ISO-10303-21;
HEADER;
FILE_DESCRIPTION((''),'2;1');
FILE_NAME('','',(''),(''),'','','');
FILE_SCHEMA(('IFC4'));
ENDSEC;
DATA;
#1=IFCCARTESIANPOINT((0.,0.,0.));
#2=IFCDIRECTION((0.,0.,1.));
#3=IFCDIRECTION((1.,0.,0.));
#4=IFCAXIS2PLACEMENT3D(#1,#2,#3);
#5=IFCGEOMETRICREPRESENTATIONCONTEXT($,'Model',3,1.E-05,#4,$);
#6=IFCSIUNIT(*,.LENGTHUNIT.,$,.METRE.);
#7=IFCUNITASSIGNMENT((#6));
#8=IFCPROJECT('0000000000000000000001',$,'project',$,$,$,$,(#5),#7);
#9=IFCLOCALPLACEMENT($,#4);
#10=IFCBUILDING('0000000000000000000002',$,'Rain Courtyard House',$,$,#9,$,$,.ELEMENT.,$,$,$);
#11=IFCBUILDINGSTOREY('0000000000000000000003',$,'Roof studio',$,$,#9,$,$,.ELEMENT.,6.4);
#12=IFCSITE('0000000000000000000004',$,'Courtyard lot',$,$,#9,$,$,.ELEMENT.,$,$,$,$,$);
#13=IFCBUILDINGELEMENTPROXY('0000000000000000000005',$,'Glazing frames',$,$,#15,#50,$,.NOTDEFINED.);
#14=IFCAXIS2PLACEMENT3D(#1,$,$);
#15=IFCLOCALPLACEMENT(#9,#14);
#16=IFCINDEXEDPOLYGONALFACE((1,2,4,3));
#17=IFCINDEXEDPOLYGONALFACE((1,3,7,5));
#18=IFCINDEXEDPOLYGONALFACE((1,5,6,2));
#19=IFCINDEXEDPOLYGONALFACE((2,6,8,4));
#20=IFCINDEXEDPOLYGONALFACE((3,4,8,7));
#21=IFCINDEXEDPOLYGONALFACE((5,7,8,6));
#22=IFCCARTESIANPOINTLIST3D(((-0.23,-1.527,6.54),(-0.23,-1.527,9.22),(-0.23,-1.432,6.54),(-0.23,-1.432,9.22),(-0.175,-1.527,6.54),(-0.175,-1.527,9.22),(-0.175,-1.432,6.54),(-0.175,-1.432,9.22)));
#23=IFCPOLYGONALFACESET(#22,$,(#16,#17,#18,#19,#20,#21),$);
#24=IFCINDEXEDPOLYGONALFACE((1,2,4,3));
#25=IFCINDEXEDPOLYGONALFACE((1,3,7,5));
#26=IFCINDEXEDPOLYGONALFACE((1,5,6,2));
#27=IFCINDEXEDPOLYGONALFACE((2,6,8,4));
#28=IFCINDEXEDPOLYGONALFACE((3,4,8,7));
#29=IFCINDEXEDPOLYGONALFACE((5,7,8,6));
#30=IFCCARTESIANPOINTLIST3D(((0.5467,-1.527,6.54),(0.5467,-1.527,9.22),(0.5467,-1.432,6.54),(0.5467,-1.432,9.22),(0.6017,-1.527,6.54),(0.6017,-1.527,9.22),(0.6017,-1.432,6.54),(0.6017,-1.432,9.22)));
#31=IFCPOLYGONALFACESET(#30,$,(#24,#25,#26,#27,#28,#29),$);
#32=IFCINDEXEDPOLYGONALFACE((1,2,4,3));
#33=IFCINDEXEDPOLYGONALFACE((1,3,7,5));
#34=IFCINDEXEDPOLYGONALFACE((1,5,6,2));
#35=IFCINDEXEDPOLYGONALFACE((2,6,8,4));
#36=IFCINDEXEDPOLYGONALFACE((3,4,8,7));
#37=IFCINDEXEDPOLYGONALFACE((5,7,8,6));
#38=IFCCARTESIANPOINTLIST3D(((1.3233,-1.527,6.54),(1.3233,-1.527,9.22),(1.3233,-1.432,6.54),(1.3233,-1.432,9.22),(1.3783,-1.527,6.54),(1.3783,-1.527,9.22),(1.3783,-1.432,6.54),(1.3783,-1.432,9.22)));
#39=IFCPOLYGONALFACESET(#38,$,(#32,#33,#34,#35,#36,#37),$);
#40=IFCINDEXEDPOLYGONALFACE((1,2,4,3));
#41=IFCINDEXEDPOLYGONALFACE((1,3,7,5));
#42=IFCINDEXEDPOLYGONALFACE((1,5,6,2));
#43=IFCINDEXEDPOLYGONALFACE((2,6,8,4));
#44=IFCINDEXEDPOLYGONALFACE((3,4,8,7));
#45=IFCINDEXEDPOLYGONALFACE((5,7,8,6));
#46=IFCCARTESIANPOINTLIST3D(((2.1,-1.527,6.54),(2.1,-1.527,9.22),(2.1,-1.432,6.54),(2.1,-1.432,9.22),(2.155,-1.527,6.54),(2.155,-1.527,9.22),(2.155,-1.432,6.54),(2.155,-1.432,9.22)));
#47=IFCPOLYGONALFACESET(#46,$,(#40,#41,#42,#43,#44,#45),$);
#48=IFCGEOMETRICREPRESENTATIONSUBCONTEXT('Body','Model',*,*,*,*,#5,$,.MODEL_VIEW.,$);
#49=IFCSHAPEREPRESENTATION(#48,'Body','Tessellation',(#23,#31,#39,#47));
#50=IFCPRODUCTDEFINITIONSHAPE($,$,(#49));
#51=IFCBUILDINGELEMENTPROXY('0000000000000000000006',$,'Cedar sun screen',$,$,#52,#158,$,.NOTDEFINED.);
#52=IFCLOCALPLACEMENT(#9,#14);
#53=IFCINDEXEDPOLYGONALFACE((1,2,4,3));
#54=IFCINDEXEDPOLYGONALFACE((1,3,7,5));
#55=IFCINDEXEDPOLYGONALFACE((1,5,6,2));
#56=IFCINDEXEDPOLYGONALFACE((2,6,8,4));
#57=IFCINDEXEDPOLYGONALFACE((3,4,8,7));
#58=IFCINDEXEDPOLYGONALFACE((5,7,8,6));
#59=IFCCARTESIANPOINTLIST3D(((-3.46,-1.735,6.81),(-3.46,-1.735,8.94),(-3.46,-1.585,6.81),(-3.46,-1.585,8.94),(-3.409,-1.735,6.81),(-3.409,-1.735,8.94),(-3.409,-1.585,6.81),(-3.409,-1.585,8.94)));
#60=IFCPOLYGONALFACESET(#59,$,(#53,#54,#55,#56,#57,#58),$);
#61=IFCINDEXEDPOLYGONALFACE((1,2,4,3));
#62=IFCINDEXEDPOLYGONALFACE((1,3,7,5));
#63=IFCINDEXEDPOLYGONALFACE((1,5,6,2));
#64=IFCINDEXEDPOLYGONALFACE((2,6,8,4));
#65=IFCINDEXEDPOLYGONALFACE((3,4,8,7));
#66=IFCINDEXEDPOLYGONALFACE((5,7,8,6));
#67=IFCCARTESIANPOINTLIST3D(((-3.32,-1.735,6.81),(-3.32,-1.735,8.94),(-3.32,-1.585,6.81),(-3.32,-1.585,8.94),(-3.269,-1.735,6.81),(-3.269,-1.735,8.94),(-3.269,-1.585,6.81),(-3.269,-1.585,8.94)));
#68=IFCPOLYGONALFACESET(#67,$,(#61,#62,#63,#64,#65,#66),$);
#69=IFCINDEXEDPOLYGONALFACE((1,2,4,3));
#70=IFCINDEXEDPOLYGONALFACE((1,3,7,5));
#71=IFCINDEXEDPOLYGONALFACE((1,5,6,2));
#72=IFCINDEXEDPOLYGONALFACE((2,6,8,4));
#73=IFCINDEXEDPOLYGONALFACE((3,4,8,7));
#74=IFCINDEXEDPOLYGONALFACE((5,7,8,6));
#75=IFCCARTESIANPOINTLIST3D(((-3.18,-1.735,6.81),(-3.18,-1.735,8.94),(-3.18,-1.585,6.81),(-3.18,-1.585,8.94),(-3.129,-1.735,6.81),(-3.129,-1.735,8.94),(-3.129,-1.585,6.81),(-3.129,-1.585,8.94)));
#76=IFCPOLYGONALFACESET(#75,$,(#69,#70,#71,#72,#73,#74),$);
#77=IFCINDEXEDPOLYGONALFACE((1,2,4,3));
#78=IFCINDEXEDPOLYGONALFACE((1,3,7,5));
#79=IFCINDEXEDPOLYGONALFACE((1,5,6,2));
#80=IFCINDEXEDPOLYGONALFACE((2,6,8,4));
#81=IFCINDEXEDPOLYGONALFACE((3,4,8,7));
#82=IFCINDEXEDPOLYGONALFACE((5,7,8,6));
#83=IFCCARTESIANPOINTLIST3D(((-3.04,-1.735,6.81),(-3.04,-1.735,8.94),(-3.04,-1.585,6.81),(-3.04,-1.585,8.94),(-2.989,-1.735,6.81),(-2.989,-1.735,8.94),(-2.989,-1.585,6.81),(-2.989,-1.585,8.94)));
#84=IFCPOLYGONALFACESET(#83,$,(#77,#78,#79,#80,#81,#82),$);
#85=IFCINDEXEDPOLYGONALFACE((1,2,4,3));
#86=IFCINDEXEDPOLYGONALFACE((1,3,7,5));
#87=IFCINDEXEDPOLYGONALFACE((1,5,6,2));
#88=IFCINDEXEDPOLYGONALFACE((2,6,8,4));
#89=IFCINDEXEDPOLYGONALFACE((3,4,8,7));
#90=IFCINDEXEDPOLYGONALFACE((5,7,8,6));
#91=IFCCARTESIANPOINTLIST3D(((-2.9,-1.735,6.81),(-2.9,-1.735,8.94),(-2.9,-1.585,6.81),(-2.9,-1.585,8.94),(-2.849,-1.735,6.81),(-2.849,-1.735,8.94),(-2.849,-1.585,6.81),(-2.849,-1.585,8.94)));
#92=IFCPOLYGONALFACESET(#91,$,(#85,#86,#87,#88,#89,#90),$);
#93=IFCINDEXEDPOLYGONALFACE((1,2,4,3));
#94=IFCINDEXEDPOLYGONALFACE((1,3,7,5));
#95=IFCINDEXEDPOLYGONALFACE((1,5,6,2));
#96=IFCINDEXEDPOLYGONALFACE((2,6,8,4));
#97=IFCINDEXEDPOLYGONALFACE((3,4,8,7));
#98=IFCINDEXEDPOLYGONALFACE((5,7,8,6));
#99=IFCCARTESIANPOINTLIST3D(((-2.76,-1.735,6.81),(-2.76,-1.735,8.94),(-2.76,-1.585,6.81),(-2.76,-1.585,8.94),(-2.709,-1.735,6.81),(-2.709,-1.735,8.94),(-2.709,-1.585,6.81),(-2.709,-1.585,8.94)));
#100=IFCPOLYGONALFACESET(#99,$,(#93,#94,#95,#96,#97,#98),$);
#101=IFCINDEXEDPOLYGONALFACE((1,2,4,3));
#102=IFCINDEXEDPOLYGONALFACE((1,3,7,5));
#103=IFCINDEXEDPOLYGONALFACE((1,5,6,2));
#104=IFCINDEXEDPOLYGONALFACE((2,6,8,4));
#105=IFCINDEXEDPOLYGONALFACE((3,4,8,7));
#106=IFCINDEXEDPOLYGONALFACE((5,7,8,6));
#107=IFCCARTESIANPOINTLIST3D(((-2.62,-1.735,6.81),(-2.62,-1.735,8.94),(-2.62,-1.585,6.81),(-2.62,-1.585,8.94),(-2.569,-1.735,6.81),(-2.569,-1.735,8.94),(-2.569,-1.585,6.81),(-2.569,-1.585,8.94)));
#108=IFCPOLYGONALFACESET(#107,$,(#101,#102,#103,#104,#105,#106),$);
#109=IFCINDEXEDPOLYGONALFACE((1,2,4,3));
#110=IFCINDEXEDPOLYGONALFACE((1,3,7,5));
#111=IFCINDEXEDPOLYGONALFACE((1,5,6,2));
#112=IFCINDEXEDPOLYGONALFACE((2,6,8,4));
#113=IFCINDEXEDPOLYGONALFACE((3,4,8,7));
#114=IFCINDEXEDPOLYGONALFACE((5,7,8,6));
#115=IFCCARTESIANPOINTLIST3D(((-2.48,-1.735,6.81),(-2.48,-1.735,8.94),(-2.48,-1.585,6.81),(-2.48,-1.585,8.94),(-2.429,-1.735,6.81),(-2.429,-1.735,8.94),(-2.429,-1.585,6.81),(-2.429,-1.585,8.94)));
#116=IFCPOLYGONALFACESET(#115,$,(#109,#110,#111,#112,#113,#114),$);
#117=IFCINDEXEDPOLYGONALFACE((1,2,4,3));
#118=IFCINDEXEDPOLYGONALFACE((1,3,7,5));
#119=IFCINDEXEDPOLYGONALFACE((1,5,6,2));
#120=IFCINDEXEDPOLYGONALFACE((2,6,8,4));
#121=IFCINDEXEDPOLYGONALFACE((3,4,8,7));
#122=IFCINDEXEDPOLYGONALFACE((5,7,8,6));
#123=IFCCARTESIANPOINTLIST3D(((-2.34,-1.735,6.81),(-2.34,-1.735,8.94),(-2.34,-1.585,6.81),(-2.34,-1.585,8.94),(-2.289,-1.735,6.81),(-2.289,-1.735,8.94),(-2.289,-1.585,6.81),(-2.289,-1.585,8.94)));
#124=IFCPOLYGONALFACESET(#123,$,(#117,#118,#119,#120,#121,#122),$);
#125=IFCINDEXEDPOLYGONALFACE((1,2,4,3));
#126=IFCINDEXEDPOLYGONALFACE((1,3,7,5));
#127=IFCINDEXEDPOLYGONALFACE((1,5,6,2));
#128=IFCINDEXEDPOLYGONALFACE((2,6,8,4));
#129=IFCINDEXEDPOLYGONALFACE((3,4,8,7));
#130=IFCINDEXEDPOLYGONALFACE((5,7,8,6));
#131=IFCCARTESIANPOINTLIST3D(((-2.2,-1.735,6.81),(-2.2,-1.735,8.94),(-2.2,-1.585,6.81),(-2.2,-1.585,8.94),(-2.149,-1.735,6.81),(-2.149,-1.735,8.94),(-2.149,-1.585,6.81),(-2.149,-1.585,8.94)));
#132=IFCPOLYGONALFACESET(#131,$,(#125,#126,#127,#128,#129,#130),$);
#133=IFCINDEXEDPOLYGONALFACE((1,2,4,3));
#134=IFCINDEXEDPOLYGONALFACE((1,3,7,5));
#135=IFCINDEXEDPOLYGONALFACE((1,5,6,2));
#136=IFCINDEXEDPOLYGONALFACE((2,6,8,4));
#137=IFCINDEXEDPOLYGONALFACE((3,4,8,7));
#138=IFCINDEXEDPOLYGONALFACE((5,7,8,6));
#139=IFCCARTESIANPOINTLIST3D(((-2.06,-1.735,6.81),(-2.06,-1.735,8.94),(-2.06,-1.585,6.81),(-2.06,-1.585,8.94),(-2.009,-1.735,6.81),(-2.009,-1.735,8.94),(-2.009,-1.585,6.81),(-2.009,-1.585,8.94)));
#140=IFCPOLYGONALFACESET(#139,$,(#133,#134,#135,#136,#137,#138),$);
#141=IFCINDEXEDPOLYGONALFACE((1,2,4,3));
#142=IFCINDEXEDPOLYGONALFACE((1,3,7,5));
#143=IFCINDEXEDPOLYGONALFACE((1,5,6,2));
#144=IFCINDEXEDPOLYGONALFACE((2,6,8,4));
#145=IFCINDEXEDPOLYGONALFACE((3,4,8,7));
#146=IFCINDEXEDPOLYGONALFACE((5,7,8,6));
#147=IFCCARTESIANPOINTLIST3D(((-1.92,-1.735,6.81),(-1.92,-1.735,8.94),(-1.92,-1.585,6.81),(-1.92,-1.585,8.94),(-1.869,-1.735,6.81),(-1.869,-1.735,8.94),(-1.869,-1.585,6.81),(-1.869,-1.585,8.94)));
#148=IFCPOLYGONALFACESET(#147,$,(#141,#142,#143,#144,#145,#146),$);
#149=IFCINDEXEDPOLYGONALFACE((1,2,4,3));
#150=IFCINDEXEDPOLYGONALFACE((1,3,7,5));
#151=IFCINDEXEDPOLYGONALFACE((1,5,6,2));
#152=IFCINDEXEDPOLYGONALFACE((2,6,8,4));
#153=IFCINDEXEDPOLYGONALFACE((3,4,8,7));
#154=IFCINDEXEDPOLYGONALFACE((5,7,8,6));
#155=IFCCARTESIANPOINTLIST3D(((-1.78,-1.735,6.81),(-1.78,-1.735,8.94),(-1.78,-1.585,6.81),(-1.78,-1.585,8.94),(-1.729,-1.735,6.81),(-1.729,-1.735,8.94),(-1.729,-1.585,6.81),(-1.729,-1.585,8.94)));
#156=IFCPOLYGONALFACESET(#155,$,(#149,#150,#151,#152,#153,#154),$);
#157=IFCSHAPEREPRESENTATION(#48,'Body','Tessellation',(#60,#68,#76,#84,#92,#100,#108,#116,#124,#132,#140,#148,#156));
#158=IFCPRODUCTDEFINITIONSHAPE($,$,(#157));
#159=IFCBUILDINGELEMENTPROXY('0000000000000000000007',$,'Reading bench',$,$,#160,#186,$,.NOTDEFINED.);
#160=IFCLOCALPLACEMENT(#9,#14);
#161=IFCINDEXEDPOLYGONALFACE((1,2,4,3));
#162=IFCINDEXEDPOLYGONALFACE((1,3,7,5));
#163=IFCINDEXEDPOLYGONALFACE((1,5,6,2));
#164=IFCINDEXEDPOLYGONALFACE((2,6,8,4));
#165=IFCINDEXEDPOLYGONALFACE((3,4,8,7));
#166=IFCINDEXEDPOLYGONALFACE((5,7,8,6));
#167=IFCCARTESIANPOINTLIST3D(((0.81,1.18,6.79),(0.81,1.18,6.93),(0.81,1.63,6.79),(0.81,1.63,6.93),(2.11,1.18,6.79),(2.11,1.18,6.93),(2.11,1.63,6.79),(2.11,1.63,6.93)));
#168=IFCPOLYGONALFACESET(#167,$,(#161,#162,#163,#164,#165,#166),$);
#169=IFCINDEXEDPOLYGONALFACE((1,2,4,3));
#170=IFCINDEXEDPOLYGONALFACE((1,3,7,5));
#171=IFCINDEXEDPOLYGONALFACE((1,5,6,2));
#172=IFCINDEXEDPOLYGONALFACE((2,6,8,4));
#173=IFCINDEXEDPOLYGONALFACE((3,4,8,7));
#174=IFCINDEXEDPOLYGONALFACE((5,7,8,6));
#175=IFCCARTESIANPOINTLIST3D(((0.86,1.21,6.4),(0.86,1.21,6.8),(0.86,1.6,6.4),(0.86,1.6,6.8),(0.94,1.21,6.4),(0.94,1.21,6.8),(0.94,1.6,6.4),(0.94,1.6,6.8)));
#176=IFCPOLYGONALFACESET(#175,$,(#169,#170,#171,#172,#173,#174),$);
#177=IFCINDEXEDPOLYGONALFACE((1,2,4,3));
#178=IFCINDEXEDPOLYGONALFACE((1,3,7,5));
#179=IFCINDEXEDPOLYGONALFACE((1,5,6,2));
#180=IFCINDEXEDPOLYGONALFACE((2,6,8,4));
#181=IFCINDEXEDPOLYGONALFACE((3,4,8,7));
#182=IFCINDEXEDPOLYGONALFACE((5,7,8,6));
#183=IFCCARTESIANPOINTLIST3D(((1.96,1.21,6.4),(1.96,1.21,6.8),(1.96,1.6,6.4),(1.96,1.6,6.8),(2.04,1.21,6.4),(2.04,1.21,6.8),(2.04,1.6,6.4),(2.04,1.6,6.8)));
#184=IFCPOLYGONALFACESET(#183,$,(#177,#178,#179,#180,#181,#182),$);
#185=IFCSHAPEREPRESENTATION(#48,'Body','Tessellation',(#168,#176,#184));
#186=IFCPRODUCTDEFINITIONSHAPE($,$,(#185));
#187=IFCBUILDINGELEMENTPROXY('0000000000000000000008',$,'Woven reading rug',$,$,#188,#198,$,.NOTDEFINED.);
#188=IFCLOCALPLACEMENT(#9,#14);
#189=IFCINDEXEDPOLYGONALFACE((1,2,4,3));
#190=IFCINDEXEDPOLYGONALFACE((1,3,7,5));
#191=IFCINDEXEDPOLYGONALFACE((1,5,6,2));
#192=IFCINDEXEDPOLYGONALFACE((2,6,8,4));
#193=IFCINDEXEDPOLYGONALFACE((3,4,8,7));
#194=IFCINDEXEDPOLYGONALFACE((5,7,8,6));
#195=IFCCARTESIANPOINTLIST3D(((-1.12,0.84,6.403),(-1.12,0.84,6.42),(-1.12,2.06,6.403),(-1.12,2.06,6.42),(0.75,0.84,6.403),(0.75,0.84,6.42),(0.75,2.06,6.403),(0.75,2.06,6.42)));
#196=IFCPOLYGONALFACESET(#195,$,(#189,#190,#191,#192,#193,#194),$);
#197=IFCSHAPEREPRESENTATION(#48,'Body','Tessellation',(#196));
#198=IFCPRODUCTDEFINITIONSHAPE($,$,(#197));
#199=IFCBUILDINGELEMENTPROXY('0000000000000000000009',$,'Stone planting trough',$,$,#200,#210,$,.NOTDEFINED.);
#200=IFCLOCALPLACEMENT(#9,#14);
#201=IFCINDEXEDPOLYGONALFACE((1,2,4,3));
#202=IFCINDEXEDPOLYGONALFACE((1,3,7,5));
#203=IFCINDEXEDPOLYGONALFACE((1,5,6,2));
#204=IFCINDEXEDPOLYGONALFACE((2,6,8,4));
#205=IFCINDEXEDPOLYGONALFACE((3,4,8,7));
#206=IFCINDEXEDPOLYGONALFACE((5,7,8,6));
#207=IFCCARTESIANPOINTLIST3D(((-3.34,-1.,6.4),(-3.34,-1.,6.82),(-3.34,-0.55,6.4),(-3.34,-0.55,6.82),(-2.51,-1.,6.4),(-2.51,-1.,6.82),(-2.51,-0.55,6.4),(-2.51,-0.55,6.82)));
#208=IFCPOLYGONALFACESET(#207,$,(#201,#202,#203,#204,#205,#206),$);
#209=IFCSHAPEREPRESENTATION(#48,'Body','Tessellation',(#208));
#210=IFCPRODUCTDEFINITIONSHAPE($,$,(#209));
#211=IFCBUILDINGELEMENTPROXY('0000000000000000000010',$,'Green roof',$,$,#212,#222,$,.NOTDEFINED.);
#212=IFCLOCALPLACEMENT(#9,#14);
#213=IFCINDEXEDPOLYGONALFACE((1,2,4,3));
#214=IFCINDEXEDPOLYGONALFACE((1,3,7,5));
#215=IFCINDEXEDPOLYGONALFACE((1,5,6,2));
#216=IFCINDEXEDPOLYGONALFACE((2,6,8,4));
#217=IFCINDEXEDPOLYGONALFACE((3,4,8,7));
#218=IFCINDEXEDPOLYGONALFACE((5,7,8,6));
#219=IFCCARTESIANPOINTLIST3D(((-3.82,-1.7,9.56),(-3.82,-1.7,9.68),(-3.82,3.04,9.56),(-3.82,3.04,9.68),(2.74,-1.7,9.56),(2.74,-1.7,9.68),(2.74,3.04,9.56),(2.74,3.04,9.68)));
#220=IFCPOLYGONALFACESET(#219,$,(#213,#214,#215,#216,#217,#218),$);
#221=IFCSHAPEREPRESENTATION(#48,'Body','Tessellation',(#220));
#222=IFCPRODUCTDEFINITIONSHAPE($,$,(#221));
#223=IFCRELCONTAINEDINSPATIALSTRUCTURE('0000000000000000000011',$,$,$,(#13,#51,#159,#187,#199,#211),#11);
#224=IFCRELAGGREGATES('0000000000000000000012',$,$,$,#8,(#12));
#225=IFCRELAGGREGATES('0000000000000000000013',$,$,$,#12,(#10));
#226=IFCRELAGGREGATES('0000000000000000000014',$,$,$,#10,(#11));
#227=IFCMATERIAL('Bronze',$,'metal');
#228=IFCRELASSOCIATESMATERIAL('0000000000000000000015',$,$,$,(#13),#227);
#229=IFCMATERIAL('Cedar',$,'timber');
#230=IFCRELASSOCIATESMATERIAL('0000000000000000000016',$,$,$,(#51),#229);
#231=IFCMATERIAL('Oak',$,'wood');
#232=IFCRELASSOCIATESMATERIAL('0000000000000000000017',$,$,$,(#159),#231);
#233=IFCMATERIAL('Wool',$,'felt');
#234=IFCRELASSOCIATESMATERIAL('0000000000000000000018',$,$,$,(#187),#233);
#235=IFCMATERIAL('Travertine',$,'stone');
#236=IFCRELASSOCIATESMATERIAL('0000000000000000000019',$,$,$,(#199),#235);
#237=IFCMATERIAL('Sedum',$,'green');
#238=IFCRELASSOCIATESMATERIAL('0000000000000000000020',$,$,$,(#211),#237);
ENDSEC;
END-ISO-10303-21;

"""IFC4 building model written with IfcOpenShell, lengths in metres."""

from ifc_helpers import new_model, si_unit, frame, origin_with_axes, origin_2d, place, context, subcontext, project, spatial, rectangle, extrude, material, element, save


model = new_model("IFC4")

# Units and contexts
model_context = context("Model", 3, precision=1e-05, world=origin_with_axes())
body_context = subcontext(model_context, "Body", "Model", "MODEL_VIEW")
ifc_project = project(units=[si_unit("LENGTHUNIT", "METRE")], contexts=[model_context])

# Site, building, storey
placement = place(None, origin_with_axes())
site = spatial("IfcSite", under=ifc_project, at=placement, Name="Courtyard lot", CompositionType="ELEMENT")
building = spatial("IfcBuilding", under=site, at=placement, Name="Rain Courtyard House", CompositionType="ELEMENT")
storey = spatial("IfcBuildingStorey", under=building, at=placement, Name="Roof studio", CompositionType="ELEMENT", Elevation=6.4)

# Building element proxies
ifc_material_1 = material(Name="Bronze", Category="metal")
element("IfcBuildingElementProxy", 1, at=placement, inside=storey, material=ifc_material_1, Name="Glazing frames", PredefinedType="NOTDEFINED", context=body_context, shape_type="SweptSolid", body=[
    extrude(rectangle(XDim=0.055, YDim=0.095, at=origin_2d()), frame((-0.2025, -1.4795, 6.54), z_axis=(0.0, 0.0, 1.0), x_axis=(1.0, 0.0, 0.0)), (0.0, 0.0, 1.0), 2.68),
    extrude(rectangle(XDim=0.055, YDim=0.095, at=origin_2d()), frame((0.5742, -1.4795, 6.54), z_axis=(0.0, 0.0, 1.0), x_axis=(1.0, 0.0, 0.0)), (0.0, 0.0, 1.0), 2.68),
    extrude(rectangle(XDim=0.055, YDim=0.095, at=origin_2d()), frame((1.3508, -1.4795, 6.54), z_axis=(0.0, 0.0, 1.0), x_axis=(1.0, 0.0, 0.0)), (0.0, 0.0, 1.0), 2.68),
    extrude(rectangle(XDim=0.055, YDim=0.095, at=origin_2d()), frame((2.1275, -1.4795, 6.54), z_axis=(0.0, 0.0, 1.0), x_axis=(1.0, 0.0, 0.0)), (0.0, 0.0, 1.0), 2.68),
])
ifc_material_2 = material(Name="Cedar", Category="timber")
element("IfcBuildingElementProxy", 2, at=placement, inside=storey, material=ifc_material_2, Name="Cedar sun screen", PredefinedType="NOTDEFINED", context=body_context, shape_type="SweptSolid", body=[
    extrude(rectangle(XDim=0.051, YDim=0.15, at=origin_2d()), frame((-3.4345, -1.66, 6.81), z_axis=(0.0, 0.0, 1.0), x_axis=(1.0, 0.0, 0.0)), (0.0, 0.0, 1.0), 2.13),
    extrude(rectangle(XDim=0.051, YDim=0.15, at=origin_2d()), frame((-3.2945, -1.66, 6.81), z_axis=(0.0, 0.0, 1.0), x_axis=(1.0, 0.0, 0.0)), (0.0, 0.0, 1.0), 2.13),
    extrude(rectangle(XDim=0.051, YDim=0.15, at=origin_2d()), frame((-3.1545, -1.66, 6.81), z_axis=(0.0, 0.0, 1.0), x_axis=(1.0, 0.0, 0.0)), (0.0, 0.0, 1.0), 2.13),
    extrude(rectangle(XDim=0.051, YDim=0.15, at=origin_2d()), frame((-3.0145, -1.66, 6.81), z_axis=(0.0, 0.0, 1.0), x_axis=(1.0, 0.0, 0.0)), (0.0, 0.0, 1.0), 2.13),
    extrude(rectangle(XDim=0.051, YDim=0.15, at=origin_2d()), frame((-2.8745, -1.66, 6.81), z_axis=(0.0, 0.0, 1.0), x_axis=(1.0, 0.0, 0.0)), (0.0, 0.0, 1.0), 2.13),
    extrude(rectangle(XDim=0.051, YDim=0.15, at=origin_2d()), frame((-2.7345, -1.66, 6.81), z_axis=(0.0, 0.0, 1.0), x_axis=(1.0, 0.0, 0.0)), (0.0, 0.0, 1.0), 2.13),
    extrude(rectangle(XDim=0.051, YDim=0.15, at=origin_2d()), frame((-2.5945, -1.66, 6.81), z_axis=(0.0, 0.0, 1.0), x_axis=(1.0, 0.0, 0.0)), (0.0, 0.0, 1.0), 2.13),
    extrude(rectangle(XDim=0.051, YDim=0.15, at=origin_2d()), frame((-2.4545, -1.66, 6.81), z_axis=(0.0, 0.0, 1.0), x_axis=(1.0, 0.0, 0.0)), (0.0, 0.0, 1.0), 2.13),
    extrude(rectangle(XDim=0.051, YDim=0.15, at=origin_2d()), frame((-2.3145, -1.66, 6.81), z_axis=(0.0, 0.0, 1.0), x_axis=(1.0, 0.0, 0.0)), (0.0, 0.0, 1.0), 2.13),
    extrude(rectangle(XDim=0.051, YDim=0.15, at=origin_2d()), frame((-2.1745, -1.66, 6.81), z_axis=(0.0, 0.0, 1.0), x_axis=(1.0, 0.0, 0.0)), (0.0, 0.0, 1.0), 2.13),
    extrude(rectangle(XDim=0.051, YDim=0.15, at=origin_2d()), frame((-2.0345, -1.66, 6.81), z_axis=(0.0, 0.0, 1.0), x_axis=(1.0, 0.0, 0.0)), (0.0, 0.0, 1.0), 2.13),
    extrude(rectangle(XDim=0.051, YDim=0.15, at=origin_2d()), frame((-1.8945, -1.66, 6.81), z_axis=(0.0, 0.0, 1.0), x_axis=(1.0, 0.0, 0.0)), (0.0, 0.0, 1.0), 2.13),
    extrude(rectangle(XDim=0.051, YDim=0.15, at=origin_2d()), frame((-1.7545, -1.66, 6.81), z_axis=(0.0, 0.0, 1.0), x_axis=(1.0, 0.0, 0.0)), (0.0, 0.0, 1.0), 2.13),
])
ifc_material_3 = material(Name="Oak", Category="wood")
element("IfcBuildingElementProxy", 3, at=placement, inside=storey, material=ifc_material_3, Name="Reading bench", PredefinedType="NOTDEFINED", context=body_context, shape_type="SweptSolid", body=[
    extrude(rectangle(XDim=1.3, YDim=0.45, at=origin_2d()), frame((1.46, 1.405, 6.79), z_axis=(0.0, 0.0, 1.0), x_axis=(1.0, 0.0, 0.0)), (0.0, 0.0, 1.0), 0.14),
    extrude(rectangle(XDim=0.08, YDim=0.39, at=origin_2d()), frame((0.9, 1.405, 6.4), z_axis=(0.0, 0.0, 1.0), x_axis=(1.0, 0.0, 0.0)), (0.0, 0.0, 1.0), 0.4),
    extrude(rectangle(XDim=0.08, YDim=0.39, at=origin_2d()), frame((2.0, 1.405, 6.4), z_axis=(0.0, 0.0, 1.0), x_axis=(1.0, 0.0, 0.0)), (0.0, 0.0, 1.0), 0.4),
])
ifc_material_4 = material(Name="Wool", Category="felt")
element("IfcBuildingElementProxy", 4, at=placement, inside=storey, material=ifc_material_4, Name="Woven reading rug", PredefinedType="NOTDEFINED", context=body_context, shape_type="SweptSolid", body=[
    extrude(rectangle(XDim=1.87, YDim=1.22, at=origin_2d()), frame((-0.185, 1.45, 6.403), z_axis=(0.0, 0.0, 1.0), x_axis=(1.0, 0.0, 0.0)), (0.0, 0.0, 1.0), 0.017),
])
ifc_material_5 = material(Name="Travertine", Category="stone")
element("IfcBuildingElementProxy", 5, at=placement, inside=storey, material=ifc_material_5, Name="Stone planting trough", PredefinedType="NOTDEFINED", context=body_context, shape_type="SweptSolid", body=[
    extrude(rectangle(XDim=0.83, YDim=0.45, at=origin_2d()), frame((-2.925, -0.775, 6.4), z_axis=(0.0, 0.0, 1.0), x_axis=(1.0, 0.0, 0.0)), (0.0, 0.0, 1.0), 0.42),
])
ifc_material_6 = material(Name="Sedum", Category="green")
element("IfcBuildingElementProxy", 6, at=placement, inside=storey, material=ifc_material_6, Name="Green roof", PredefinedType="NOTDEFINED", context=body_context, shape_type="SweptSolid", body=[
    extrude(rectangle(XDim=6.56, YDim=4.74, at=origin_2d()), frame((-0.54, 0.67, 9.56), z_axis=(0.0, 0.0, 1.0), x_axis=(1.0, 0.0, 0.0)), (0.0, 0.0, 1.0), 0.12),
])

save(model, "model.ifc")
